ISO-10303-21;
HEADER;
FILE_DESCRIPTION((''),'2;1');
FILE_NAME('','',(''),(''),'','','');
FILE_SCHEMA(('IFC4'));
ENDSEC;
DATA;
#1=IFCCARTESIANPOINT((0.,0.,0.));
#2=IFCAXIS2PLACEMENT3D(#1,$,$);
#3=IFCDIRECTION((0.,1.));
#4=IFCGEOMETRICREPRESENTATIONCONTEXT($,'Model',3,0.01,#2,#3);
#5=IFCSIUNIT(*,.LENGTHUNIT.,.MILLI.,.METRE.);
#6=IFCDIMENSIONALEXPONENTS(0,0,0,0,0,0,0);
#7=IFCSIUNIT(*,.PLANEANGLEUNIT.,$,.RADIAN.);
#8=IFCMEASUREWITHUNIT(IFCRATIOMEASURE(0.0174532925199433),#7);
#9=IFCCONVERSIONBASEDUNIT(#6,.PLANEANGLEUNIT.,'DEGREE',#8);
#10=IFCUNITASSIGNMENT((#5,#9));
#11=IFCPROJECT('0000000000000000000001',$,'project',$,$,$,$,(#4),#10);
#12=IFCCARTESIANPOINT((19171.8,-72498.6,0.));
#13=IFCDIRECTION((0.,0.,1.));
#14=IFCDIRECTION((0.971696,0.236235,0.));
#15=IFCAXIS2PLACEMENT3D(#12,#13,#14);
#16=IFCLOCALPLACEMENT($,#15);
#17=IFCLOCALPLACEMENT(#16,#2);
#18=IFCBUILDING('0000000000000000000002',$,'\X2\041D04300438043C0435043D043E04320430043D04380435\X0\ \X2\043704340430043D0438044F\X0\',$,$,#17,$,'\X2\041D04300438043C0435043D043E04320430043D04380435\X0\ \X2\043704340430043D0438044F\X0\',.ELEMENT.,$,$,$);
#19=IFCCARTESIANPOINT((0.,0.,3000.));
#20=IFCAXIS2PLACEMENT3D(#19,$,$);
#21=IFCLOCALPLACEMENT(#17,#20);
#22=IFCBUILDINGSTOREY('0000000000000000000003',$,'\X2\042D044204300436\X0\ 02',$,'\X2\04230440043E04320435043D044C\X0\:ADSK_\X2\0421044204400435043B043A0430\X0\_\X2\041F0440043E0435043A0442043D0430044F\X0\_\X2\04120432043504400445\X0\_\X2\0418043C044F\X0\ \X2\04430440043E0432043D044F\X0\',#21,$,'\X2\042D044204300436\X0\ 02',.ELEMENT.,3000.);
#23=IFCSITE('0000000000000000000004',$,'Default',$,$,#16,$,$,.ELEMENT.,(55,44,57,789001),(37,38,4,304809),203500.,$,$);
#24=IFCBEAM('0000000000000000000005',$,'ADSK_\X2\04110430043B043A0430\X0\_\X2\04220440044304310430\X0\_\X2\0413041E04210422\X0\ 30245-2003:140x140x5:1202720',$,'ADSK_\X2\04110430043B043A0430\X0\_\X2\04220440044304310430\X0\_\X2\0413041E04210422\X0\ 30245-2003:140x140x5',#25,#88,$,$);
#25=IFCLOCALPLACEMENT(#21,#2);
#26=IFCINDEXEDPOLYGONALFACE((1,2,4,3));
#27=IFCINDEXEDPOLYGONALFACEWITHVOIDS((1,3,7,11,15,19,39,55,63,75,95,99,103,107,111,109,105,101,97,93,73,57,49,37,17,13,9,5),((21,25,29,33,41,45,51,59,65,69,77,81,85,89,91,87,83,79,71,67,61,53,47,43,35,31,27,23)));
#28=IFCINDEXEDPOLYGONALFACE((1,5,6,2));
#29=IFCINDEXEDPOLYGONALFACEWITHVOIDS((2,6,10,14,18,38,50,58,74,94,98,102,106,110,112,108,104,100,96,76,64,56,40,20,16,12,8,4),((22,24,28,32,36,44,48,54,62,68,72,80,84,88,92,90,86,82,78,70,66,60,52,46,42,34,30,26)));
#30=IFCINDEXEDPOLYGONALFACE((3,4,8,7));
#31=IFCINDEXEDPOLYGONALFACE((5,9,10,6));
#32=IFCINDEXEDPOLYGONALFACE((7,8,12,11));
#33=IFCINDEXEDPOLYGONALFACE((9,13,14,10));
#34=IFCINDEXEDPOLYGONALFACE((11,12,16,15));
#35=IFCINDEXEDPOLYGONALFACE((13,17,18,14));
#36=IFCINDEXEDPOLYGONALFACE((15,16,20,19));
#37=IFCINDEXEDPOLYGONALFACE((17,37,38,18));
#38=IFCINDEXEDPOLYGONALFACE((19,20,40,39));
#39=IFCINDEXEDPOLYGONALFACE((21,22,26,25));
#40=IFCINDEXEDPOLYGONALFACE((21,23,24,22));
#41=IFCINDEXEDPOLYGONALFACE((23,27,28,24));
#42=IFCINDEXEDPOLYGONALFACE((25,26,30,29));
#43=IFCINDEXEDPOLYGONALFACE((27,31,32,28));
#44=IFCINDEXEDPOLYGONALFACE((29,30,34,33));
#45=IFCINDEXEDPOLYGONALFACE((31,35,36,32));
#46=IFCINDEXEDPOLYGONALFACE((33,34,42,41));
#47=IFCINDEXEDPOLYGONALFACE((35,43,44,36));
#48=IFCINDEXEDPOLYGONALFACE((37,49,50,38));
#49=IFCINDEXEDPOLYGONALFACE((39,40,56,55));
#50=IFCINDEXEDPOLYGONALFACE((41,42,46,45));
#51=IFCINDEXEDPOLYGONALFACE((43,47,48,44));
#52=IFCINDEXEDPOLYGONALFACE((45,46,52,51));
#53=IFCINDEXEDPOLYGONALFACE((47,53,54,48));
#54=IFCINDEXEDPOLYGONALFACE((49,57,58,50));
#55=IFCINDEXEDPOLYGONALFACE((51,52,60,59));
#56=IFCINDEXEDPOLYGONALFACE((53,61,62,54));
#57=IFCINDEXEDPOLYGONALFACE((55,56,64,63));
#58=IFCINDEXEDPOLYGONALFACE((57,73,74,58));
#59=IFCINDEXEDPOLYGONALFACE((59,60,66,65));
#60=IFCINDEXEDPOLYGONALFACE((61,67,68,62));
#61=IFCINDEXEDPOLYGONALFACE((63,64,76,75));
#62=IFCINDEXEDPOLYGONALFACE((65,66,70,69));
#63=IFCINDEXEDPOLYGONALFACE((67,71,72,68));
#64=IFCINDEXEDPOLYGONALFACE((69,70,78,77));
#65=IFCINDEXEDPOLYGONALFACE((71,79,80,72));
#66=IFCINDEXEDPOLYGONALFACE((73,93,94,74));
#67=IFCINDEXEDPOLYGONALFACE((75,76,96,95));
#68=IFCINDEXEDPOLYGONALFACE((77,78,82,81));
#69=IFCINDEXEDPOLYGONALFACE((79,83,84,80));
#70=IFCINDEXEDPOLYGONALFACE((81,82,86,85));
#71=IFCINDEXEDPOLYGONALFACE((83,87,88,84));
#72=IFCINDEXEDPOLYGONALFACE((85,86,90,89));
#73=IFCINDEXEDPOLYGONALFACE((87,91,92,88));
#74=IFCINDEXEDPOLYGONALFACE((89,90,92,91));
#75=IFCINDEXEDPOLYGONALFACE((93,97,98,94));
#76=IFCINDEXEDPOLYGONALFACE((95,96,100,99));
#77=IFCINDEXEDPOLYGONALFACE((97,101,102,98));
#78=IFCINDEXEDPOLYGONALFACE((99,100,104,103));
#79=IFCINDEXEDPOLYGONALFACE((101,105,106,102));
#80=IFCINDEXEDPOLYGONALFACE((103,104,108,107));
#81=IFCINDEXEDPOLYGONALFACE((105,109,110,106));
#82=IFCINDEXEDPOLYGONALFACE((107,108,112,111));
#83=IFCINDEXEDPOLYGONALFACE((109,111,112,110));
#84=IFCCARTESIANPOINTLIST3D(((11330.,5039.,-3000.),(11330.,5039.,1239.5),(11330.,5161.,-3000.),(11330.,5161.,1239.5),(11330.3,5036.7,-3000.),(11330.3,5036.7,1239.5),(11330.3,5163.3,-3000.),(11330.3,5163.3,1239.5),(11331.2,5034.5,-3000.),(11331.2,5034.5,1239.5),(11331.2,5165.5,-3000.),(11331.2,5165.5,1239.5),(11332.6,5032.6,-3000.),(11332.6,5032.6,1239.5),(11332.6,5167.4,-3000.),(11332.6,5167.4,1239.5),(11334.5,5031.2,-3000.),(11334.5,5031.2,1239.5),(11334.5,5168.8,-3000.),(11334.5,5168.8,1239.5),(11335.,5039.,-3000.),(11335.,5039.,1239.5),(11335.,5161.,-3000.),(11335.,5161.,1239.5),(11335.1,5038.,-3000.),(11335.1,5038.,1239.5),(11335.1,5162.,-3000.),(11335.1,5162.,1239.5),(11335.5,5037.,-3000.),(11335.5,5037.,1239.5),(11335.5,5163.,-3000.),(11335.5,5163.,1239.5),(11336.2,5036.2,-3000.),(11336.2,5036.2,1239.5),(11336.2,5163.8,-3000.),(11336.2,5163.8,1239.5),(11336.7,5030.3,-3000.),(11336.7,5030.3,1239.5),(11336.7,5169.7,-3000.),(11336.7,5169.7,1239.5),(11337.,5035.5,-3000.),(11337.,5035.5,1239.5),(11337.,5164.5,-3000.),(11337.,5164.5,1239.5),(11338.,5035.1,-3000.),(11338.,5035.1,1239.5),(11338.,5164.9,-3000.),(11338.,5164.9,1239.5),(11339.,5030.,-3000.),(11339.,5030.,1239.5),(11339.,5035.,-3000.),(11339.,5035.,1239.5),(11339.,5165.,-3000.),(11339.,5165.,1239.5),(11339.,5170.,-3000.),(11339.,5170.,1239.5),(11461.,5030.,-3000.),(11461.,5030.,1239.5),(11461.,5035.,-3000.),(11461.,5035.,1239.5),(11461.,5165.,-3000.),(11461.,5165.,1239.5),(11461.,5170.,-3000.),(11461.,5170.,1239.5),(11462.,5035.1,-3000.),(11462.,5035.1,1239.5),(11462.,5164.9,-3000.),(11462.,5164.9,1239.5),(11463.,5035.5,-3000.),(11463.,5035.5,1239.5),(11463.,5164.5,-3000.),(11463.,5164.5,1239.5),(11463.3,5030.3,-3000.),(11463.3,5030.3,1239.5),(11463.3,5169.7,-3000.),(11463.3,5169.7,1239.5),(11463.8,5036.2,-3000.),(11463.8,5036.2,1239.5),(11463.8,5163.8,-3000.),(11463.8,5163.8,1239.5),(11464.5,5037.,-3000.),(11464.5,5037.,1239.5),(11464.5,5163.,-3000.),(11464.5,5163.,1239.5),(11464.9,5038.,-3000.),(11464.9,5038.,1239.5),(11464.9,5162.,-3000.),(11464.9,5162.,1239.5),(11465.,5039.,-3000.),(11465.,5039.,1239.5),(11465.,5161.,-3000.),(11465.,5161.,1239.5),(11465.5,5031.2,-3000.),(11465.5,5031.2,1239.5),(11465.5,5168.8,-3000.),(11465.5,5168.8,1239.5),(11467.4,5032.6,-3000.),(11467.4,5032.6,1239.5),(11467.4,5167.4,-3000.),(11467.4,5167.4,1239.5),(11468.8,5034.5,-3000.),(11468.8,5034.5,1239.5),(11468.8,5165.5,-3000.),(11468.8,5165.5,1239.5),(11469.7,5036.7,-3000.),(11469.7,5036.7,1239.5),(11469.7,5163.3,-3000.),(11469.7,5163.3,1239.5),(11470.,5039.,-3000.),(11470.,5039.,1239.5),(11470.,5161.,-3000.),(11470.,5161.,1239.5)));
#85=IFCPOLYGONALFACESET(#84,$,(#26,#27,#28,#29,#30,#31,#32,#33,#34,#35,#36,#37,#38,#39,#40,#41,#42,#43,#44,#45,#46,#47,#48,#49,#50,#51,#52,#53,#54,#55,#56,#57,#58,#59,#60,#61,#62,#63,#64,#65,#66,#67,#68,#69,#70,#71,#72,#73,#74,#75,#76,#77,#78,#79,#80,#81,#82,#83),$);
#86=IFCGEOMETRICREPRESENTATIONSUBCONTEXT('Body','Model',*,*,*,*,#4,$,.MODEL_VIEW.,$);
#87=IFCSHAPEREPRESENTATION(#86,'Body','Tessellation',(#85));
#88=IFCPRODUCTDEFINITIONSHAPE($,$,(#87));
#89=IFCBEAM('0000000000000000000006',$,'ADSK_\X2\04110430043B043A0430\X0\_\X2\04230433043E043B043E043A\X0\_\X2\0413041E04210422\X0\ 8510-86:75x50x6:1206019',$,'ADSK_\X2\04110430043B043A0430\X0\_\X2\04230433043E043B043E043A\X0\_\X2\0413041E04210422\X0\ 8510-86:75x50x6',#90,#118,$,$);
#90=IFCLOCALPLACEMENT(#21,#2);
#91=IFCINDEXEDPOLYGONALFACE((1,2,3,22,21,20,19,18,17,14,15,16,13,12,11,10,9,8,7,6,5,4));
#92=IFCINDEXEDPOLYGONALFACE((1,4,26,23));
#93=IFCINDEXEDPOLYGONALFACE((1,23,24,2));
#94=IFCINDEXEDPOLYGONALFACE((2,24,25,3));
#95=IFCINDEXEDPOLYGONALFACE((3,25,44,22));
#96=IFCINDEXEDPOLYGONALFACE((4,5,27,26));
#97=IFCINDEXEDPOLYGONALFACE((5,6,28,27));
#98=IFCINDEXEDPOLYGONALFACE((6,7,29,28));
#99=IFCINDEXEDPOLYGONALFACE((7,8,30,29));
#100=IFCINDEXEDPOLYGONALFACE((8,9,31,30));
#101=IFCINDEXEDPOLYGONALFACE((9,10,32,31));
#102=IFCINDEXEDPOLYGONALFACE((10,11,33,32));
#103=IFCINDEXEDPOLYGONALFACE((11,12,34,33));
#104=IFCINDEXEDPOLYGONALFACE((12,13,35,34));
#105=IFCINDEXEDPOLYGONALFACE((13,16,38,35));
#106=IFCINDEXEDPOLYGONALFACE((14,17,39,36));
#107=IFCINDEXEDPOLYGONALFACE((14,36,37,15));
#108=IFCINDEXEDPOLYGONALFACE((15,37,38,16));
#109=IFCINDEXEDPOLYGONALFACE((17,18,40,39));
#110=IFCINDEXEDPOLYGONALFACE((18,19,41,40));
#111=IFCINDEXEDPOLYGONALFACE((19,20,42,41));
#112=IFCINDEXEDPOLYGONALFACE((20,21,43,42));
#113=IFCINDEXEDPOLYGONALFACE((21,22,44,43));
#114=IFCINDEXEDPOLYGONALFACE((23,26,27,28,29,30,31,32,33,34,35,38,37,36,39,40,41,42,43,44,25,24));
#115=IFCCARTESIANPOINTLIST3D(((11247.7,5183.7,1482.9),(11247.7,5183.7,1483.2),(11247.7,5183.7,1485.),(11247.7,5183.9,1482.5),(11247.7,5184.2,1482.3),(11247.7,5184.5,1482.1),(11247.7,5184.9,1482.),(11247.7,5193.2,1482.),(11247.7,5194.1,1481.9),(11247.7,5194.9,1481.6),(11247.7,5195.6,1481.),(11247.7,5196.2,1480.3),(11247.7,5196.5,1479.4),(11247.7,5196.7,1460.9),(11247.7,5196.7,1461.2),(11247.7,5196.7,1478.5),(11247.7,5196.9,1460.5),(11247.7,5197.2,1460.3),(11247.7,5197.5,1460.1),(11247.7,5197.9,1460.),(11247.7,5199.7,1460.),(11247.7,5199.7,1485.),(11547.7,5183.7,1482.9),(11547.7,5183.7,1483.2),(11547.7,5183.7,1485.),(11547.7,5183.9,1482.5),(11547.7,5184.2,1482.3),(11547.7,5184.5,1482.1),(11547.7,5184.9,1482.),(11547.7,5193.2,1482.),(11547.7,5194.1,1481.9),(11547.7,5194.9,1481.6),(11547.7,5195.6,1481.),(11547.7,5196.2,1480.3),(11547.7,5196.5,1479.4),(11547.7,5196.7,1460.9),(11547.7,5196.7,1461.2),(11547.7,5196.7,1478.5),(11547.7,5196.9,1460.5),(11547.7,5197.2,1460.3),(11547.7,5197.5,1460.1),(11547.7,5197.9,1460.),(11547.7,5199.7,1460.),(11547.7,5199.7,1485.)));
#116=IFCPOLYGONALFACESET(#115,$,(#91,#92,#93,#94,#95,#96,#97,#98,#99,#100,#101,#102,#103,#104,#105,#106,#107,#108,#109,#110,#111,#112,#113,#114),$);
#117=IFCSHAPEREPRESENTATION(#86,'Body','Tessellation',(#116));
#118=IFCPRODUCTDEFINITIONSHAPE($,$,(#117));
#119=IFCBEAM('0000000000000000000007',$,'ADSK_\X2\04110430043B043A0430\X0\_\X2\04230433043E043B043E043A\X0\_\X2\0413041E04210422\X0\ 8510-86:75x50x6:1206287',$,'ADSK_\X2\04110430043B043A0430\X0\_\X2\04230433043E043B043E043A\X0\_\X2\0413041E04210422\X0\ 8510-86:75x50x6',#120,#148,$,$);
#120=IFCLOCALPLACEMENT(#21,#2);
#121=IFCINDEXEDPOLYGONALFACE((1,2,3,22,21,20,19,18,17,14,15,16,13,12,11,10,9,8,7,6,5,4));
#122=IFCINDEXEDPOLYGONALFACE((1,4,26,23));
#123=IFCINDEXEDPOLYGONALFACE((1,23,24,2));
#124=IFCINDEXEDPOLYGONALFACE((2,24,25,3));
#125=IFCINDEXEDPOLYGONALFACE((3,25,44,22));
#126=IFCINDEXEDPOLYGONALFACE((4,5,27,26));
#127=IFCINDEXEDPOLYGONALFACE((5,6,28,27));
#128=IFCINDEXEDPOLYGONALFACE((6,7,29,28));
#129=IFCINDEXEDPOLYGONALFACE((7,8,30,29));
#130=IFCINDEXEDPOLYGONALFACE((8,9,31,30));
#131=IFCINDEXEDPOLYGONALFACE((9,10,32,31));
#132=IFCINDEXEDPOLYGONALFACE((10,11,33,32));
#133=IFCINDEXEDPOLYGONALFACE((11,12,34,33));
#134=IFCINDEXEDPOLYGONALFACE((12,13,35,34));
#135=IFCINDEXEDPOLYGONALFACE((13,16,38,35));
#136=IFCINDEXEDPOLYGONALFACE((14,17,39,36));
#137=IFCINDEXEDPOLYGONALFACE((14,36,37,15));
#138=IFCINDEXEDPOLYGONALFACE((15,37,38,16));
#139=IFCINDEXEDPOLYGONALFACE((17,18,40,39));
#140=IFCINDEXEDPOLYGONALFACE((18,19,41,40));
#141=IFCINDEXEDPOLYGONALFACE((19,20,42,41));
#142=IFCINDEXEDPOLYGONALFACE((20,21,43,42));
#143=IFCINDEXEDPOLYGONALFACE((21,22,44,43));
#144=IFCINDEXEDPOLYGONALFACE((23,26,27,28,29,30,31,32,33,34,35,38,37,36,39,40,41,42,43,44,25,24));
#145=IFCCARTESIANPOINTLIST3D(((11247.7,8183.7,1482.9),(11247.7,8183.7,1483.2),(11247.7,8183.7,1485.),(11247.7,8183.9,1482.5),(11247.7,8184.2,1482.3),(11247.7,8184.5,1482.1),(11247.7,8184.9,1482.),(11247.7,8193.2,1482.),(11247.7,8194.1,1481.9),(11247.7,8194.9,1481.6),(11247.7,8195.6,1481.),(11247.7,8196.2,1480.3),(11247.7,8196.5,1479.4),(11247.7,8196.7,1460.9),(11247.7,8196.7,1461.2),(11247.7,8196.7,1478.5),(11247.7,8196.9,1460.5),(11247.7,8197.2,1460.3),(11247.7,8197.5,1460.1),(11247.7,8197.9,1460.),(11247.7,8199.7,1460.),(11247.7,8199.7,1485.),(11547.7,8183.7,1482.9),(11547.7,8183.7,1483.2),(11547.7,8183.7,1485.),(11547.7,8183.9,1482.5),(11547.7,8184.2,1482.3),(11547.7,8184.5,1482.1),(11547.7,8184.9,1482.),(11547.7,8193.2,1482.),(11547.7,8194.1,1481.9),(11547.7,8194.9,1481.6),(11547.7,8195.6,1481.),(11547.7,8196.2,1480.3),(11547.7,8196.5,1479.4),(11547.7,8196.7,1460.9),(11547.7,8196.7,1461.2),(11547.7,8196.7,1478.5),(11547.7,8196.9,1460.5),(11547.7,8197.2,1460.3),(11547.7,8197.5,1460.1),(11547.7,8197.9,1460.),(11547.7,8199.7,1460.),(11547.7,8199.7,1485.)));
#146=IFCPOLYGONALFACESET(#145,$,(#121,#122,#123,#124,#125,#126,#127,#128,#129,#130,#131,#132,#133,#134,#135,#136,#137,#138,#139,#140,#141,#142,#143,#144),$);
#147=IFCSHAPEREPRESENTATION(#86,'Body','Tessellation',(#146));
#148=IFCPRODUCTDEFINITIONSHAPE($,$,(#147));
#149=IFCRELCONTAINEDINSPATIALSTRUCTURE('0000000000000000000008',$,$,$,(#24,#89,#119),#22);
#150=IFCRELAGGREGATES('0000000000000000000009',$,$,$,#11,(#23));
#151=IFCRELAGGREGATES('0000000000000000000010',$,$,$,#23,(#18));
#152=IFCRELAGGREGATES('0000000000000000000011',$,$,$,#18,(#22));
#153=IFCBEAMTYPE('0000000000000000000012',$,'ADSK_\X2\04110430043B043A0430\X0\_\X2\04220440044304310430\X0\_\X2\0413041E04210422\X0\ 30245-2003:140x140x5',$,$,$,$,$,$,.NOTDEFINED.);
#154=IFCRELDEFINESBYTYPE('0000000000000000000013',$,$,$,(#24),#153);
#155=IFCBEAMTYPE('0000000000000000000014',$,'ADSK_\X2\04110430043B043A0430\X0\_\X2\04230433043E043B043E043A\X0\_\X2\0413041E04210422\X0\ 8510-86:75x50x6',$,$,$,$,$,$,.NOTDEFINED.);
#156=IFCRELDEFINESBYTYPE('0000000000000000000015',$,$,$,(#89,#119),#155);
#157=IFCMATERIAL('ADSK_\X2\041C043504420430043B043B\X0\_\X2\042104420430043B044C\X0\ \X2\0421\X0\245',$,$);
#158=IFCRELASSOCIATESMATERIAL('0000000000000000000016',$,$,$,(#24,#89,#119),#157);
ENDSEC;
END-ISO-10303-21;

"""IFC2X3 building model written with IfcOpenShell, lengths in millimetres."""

from ifc_helpers import new_model, entity, si_unit, converted_unit, direction, frame, frame_2d, origin, place, context, subcontext, project, spatial, polyline, circle_curve, parameter, trimmed, segment, composite_curve, outline, extrude, material, type_object, element, save


model = new_model("IFC2X3")

# Units and contexts
model_context = context("Model", 3, precision=0.01, world=origin(), true_north=direction((0.0, 1.0)))
body_context = subcontext(model_context, "Body", "Model", "MODEL_VIEW")
ifc_project = project(units=[si_unit("LENGTHUNIT", "METRE", prefix="MILLI"), converted_unit("PLANEANGLEUNIT", "DEGREE", entity("IfcRatioMeasure", 0.0174532925199433), si_unit("PLANEANGLEUNIT", "RADIAN"), dimensions=[0, 0, 0, 0, 0, 0, 0])], contexts=[model_context])

# Site, building, storey
site_placement = place(None, frame((19171.8, -72498.6, 0.0), z_axis=(0.0, 0.0, 1.0), x_axis=(0.971696, 0.236235, 0.0)))
site = spatial("IfcSite", under=ifc_project, at=site_placement, Name="Default", CompositionType="ELEMENT", RefLatitude=(55, 44, 57, 789001), RefLongitude=(37, 38, 4, 304809), RefElevation=203500.0)
building_placement = place(site_placement, origin())
building = spatial("IfcBuilding", under=site, at=building_placement, Name="Наименование здания", LongName="Наименование здания", CompositionType="ELEMENT")
storey_placement = place(building_placement, frame((0.0, 0.0, 3000.0)))
storey = spatial("IfcBuildingStorey", under=building, at=storey_placement, Name="Этаж 02", ObjectType="Уровень:ADSK_Стрелка_Проектная_Вверх_Имя уровня", LongName="Этаж 02", CompositionType="ELEMENT", Elevation=3000.0)

# Beams
ifc_material_1 = material(Name="ADSK_Металл_Сталь С245")
beam_type_1 = type_object("IfcBeamType", Name="ADSK_Балка_Труба_ГОСТ 30245-2003:140x140x5", PredefinedType="NOTDEFINED")
beam_1_placement = place(storey_placement, frame((11328.4, 5028.4, -3000.0), z_axis=(1.0, 0.0, 0.0), x_axis=(0.0, 0.0, -1.0)))
element("IfcBeam", 1, at=beam_1_placement, inside=storey, type_object=beam_type_1, material=ifc_material_1, Name="ADSK_Балка_Труба_ГОСТ 30245-2003:140x140x5:1202720", ObjectType="ADSK_Балка_Труба_ГОСТ 30245-2003:140x140x5", context=body_context, shape_type="SweptSolid", body=[
    extrude(outline(composite_curve([segment(trimmed(circle_curve(frame_2d((61.0, -61.0), x_axis=(1.0, 0.0)), 9.0), [parameter(270.0)], [parameter(0.0)], True, "PARAMETER"), True, "CONTINUOUS"), segment(polyline([(70.0, -61.0), (70.0, 61.0)]), True, "CONTINUOUS"), segment(trimmed(circle_curve(frame_2d((61.0, 61.0), x_axis=(1.0, 0.0)), 9.0), [parameter(0.0)], [parameter(90.0)], True, "PARAMETER"), True, "CONTINUOUS"), segment(polyline([(61.0, 70.0), (-61.0, 70.0)]), True, "CONTINUOUS"), segment(trimmed(circle_curve(frame_2d((-61.0, 61.0), x_axis=(1.0, 0.0)), 9.0), [parameter(90.0)], [parameter(180.0)], True, "PARAMETER"), True, "CONTINUOUS"), segment(polyline([(-70.0, 61.0), (-70.0, -61.0)]), True, "CONTINUOUS"), segment(trimmed(circle_curve(frame_2d((-61.0, -61.0), x_axis=(1.0, 0.0)), 9.0), [parameter(180.0)], [parameter(270.0)], True, "PARAMETER"), True, "CONTINUOUS"), segment(polyline([(-61.0, -70.0), (61.0, -70.0)]), True, "CONTINUOUS")], self_intersect=False), holes=[composite_curve([segment(polyline([(61.0, -65.0), (-61.0, -65.0)]), True, "CONTINUOUS"), segment(trimmed(circle_curve(frame_2d((-61.0, -61.0), x_axis=(1.0, 0.0)), 4.0), [parameter(180.0)], [parameter(270.0)], True, "PARAMETER"), False, "CONTINUOUS"), segment(polyline([(-65.0, -61.0), (-65.0, 61.0)]), True, "CONTINUOUS"), segment(trimmed(circle_curve(frame_2d((-61.0, 61.0), x_axis=(1.0, 0.0)), 4.0), [parameter(90.0)], [parameter(180.0)], True, "PARAMETER"), False, "CONTINUOUS"), segment(polyline([(-61.0, 65.0), (61.0, 65.0)]), True, "CONTINUOUS"), segment(trimmed(circle_curve(frame_2d((61.0, 61.0), x_axis=(1.0, 0.0)), 4.0), [parameter(0.0)], [parameter(90.0)], True, "PARAMETER"), False, "CONTINUOUS"), segment(polyline([(65.0, 61.0), (65.0, -61.0)]), True, "CONTINUOUS"), segment(trimmed(circle_curve(frame_2d((61.0, -61.0), x_axis=(1.0, 0.0)), 4.0), [parameter(270.0)], [parameter(0.0)], True, "PARAMETER"), False, "CONTINUOUS")], self_intersect=False)]), frame((-4239.5, 71.6, 71.6), z_axis=(1.0, 0.0, 0.0), x_axis=(0.0, 0.0, 1.0)), (0.0, 0.0, 1.0), 4239.5),
])
beam_type_2 = type_object("IfcBeamType", Name="ADSK_Балка_Уголок_ГОСТ 8510-86:75x50x6", PredefinedType="NOTDEFINED")
for number, where, name in (
    (2, (11247.7, 5195.5, 1460.0), "ADSK_Балка_Уголок_ГОСТ 8510-86:75x50x6:1206019"),
    (3, (11247.7, 8195.5, 1460.0), "ADSK_Балка_Уголок_ГОСТ 8510-86:75x50x6:1206287"),
):
    element("IfcBeam", number, at=place(storey_placement, frame(where)), inside=storey, type_object=beam_type_2, material=ifc_material_1, Name=name, ObjectType="ADSK_Балка_Уголок_ГОСТ 8510-86:75x50x6", context=body_context, shape_type="SweptSolid", body=[
        extrude(outline(composite_curve([segment(polyline([(-9.8, -9.2), (-8.0, -9.2)]), True, "CONTINUOUS"), segment(trimmed(circle_curve(frame_2d((-8.0, -8.0), x_axis=(0.0, -1.0)), 1.2), [parameter(0.0)], [parameter(90.0)], True, "PARAMETER"), True, "CONTINUOUS"), segment(polyline([(-6.8, -8.0), (-6.8, 0.3)]), True, "CONTINUOUS"), segment(trimmed(circle_curve(frame_2d((-3.3, 0.3), x_axis=(-1.0, 0.0)), 3.5), [parameter(270.0)], [parameter(0.0)], True, "PARAMETER"), False, "CONTINUOUS"), segment(polyline([(-3.3, 3.8), (14.0, 3.8)]), True, "CONTINUOUS"), segment(trimmed(circle_curve(frame_2d((14.0, 5.0), x_axis=(0.0, -1.0)), 1.2), [parameter(0.0)], [parameter(90.0)], True, "PARAMETER"), True, "CONTINUOUS"), segment(polyline([(15.2, 5.0), (15.2, 6.8)]), True, "CONTINUOUS"), segment(polyline([(15.2, 6.8), (-9.8, 6.8)]), True, "CONTINUOUS"), segment(polyline([(-9.8, 6.8), (-9.8, -9.2)]), True, "CONTINUOUS")], self_intersect=False)), frame((0.0, -2.6, 15.2), z_axis=(1.0, 0.0, 0.0), x_axis=(0.0, 0.0, -1.0)), (0.0, 0.0, 1.0), 300.0),
    ])

save(model, "model.ifc")
